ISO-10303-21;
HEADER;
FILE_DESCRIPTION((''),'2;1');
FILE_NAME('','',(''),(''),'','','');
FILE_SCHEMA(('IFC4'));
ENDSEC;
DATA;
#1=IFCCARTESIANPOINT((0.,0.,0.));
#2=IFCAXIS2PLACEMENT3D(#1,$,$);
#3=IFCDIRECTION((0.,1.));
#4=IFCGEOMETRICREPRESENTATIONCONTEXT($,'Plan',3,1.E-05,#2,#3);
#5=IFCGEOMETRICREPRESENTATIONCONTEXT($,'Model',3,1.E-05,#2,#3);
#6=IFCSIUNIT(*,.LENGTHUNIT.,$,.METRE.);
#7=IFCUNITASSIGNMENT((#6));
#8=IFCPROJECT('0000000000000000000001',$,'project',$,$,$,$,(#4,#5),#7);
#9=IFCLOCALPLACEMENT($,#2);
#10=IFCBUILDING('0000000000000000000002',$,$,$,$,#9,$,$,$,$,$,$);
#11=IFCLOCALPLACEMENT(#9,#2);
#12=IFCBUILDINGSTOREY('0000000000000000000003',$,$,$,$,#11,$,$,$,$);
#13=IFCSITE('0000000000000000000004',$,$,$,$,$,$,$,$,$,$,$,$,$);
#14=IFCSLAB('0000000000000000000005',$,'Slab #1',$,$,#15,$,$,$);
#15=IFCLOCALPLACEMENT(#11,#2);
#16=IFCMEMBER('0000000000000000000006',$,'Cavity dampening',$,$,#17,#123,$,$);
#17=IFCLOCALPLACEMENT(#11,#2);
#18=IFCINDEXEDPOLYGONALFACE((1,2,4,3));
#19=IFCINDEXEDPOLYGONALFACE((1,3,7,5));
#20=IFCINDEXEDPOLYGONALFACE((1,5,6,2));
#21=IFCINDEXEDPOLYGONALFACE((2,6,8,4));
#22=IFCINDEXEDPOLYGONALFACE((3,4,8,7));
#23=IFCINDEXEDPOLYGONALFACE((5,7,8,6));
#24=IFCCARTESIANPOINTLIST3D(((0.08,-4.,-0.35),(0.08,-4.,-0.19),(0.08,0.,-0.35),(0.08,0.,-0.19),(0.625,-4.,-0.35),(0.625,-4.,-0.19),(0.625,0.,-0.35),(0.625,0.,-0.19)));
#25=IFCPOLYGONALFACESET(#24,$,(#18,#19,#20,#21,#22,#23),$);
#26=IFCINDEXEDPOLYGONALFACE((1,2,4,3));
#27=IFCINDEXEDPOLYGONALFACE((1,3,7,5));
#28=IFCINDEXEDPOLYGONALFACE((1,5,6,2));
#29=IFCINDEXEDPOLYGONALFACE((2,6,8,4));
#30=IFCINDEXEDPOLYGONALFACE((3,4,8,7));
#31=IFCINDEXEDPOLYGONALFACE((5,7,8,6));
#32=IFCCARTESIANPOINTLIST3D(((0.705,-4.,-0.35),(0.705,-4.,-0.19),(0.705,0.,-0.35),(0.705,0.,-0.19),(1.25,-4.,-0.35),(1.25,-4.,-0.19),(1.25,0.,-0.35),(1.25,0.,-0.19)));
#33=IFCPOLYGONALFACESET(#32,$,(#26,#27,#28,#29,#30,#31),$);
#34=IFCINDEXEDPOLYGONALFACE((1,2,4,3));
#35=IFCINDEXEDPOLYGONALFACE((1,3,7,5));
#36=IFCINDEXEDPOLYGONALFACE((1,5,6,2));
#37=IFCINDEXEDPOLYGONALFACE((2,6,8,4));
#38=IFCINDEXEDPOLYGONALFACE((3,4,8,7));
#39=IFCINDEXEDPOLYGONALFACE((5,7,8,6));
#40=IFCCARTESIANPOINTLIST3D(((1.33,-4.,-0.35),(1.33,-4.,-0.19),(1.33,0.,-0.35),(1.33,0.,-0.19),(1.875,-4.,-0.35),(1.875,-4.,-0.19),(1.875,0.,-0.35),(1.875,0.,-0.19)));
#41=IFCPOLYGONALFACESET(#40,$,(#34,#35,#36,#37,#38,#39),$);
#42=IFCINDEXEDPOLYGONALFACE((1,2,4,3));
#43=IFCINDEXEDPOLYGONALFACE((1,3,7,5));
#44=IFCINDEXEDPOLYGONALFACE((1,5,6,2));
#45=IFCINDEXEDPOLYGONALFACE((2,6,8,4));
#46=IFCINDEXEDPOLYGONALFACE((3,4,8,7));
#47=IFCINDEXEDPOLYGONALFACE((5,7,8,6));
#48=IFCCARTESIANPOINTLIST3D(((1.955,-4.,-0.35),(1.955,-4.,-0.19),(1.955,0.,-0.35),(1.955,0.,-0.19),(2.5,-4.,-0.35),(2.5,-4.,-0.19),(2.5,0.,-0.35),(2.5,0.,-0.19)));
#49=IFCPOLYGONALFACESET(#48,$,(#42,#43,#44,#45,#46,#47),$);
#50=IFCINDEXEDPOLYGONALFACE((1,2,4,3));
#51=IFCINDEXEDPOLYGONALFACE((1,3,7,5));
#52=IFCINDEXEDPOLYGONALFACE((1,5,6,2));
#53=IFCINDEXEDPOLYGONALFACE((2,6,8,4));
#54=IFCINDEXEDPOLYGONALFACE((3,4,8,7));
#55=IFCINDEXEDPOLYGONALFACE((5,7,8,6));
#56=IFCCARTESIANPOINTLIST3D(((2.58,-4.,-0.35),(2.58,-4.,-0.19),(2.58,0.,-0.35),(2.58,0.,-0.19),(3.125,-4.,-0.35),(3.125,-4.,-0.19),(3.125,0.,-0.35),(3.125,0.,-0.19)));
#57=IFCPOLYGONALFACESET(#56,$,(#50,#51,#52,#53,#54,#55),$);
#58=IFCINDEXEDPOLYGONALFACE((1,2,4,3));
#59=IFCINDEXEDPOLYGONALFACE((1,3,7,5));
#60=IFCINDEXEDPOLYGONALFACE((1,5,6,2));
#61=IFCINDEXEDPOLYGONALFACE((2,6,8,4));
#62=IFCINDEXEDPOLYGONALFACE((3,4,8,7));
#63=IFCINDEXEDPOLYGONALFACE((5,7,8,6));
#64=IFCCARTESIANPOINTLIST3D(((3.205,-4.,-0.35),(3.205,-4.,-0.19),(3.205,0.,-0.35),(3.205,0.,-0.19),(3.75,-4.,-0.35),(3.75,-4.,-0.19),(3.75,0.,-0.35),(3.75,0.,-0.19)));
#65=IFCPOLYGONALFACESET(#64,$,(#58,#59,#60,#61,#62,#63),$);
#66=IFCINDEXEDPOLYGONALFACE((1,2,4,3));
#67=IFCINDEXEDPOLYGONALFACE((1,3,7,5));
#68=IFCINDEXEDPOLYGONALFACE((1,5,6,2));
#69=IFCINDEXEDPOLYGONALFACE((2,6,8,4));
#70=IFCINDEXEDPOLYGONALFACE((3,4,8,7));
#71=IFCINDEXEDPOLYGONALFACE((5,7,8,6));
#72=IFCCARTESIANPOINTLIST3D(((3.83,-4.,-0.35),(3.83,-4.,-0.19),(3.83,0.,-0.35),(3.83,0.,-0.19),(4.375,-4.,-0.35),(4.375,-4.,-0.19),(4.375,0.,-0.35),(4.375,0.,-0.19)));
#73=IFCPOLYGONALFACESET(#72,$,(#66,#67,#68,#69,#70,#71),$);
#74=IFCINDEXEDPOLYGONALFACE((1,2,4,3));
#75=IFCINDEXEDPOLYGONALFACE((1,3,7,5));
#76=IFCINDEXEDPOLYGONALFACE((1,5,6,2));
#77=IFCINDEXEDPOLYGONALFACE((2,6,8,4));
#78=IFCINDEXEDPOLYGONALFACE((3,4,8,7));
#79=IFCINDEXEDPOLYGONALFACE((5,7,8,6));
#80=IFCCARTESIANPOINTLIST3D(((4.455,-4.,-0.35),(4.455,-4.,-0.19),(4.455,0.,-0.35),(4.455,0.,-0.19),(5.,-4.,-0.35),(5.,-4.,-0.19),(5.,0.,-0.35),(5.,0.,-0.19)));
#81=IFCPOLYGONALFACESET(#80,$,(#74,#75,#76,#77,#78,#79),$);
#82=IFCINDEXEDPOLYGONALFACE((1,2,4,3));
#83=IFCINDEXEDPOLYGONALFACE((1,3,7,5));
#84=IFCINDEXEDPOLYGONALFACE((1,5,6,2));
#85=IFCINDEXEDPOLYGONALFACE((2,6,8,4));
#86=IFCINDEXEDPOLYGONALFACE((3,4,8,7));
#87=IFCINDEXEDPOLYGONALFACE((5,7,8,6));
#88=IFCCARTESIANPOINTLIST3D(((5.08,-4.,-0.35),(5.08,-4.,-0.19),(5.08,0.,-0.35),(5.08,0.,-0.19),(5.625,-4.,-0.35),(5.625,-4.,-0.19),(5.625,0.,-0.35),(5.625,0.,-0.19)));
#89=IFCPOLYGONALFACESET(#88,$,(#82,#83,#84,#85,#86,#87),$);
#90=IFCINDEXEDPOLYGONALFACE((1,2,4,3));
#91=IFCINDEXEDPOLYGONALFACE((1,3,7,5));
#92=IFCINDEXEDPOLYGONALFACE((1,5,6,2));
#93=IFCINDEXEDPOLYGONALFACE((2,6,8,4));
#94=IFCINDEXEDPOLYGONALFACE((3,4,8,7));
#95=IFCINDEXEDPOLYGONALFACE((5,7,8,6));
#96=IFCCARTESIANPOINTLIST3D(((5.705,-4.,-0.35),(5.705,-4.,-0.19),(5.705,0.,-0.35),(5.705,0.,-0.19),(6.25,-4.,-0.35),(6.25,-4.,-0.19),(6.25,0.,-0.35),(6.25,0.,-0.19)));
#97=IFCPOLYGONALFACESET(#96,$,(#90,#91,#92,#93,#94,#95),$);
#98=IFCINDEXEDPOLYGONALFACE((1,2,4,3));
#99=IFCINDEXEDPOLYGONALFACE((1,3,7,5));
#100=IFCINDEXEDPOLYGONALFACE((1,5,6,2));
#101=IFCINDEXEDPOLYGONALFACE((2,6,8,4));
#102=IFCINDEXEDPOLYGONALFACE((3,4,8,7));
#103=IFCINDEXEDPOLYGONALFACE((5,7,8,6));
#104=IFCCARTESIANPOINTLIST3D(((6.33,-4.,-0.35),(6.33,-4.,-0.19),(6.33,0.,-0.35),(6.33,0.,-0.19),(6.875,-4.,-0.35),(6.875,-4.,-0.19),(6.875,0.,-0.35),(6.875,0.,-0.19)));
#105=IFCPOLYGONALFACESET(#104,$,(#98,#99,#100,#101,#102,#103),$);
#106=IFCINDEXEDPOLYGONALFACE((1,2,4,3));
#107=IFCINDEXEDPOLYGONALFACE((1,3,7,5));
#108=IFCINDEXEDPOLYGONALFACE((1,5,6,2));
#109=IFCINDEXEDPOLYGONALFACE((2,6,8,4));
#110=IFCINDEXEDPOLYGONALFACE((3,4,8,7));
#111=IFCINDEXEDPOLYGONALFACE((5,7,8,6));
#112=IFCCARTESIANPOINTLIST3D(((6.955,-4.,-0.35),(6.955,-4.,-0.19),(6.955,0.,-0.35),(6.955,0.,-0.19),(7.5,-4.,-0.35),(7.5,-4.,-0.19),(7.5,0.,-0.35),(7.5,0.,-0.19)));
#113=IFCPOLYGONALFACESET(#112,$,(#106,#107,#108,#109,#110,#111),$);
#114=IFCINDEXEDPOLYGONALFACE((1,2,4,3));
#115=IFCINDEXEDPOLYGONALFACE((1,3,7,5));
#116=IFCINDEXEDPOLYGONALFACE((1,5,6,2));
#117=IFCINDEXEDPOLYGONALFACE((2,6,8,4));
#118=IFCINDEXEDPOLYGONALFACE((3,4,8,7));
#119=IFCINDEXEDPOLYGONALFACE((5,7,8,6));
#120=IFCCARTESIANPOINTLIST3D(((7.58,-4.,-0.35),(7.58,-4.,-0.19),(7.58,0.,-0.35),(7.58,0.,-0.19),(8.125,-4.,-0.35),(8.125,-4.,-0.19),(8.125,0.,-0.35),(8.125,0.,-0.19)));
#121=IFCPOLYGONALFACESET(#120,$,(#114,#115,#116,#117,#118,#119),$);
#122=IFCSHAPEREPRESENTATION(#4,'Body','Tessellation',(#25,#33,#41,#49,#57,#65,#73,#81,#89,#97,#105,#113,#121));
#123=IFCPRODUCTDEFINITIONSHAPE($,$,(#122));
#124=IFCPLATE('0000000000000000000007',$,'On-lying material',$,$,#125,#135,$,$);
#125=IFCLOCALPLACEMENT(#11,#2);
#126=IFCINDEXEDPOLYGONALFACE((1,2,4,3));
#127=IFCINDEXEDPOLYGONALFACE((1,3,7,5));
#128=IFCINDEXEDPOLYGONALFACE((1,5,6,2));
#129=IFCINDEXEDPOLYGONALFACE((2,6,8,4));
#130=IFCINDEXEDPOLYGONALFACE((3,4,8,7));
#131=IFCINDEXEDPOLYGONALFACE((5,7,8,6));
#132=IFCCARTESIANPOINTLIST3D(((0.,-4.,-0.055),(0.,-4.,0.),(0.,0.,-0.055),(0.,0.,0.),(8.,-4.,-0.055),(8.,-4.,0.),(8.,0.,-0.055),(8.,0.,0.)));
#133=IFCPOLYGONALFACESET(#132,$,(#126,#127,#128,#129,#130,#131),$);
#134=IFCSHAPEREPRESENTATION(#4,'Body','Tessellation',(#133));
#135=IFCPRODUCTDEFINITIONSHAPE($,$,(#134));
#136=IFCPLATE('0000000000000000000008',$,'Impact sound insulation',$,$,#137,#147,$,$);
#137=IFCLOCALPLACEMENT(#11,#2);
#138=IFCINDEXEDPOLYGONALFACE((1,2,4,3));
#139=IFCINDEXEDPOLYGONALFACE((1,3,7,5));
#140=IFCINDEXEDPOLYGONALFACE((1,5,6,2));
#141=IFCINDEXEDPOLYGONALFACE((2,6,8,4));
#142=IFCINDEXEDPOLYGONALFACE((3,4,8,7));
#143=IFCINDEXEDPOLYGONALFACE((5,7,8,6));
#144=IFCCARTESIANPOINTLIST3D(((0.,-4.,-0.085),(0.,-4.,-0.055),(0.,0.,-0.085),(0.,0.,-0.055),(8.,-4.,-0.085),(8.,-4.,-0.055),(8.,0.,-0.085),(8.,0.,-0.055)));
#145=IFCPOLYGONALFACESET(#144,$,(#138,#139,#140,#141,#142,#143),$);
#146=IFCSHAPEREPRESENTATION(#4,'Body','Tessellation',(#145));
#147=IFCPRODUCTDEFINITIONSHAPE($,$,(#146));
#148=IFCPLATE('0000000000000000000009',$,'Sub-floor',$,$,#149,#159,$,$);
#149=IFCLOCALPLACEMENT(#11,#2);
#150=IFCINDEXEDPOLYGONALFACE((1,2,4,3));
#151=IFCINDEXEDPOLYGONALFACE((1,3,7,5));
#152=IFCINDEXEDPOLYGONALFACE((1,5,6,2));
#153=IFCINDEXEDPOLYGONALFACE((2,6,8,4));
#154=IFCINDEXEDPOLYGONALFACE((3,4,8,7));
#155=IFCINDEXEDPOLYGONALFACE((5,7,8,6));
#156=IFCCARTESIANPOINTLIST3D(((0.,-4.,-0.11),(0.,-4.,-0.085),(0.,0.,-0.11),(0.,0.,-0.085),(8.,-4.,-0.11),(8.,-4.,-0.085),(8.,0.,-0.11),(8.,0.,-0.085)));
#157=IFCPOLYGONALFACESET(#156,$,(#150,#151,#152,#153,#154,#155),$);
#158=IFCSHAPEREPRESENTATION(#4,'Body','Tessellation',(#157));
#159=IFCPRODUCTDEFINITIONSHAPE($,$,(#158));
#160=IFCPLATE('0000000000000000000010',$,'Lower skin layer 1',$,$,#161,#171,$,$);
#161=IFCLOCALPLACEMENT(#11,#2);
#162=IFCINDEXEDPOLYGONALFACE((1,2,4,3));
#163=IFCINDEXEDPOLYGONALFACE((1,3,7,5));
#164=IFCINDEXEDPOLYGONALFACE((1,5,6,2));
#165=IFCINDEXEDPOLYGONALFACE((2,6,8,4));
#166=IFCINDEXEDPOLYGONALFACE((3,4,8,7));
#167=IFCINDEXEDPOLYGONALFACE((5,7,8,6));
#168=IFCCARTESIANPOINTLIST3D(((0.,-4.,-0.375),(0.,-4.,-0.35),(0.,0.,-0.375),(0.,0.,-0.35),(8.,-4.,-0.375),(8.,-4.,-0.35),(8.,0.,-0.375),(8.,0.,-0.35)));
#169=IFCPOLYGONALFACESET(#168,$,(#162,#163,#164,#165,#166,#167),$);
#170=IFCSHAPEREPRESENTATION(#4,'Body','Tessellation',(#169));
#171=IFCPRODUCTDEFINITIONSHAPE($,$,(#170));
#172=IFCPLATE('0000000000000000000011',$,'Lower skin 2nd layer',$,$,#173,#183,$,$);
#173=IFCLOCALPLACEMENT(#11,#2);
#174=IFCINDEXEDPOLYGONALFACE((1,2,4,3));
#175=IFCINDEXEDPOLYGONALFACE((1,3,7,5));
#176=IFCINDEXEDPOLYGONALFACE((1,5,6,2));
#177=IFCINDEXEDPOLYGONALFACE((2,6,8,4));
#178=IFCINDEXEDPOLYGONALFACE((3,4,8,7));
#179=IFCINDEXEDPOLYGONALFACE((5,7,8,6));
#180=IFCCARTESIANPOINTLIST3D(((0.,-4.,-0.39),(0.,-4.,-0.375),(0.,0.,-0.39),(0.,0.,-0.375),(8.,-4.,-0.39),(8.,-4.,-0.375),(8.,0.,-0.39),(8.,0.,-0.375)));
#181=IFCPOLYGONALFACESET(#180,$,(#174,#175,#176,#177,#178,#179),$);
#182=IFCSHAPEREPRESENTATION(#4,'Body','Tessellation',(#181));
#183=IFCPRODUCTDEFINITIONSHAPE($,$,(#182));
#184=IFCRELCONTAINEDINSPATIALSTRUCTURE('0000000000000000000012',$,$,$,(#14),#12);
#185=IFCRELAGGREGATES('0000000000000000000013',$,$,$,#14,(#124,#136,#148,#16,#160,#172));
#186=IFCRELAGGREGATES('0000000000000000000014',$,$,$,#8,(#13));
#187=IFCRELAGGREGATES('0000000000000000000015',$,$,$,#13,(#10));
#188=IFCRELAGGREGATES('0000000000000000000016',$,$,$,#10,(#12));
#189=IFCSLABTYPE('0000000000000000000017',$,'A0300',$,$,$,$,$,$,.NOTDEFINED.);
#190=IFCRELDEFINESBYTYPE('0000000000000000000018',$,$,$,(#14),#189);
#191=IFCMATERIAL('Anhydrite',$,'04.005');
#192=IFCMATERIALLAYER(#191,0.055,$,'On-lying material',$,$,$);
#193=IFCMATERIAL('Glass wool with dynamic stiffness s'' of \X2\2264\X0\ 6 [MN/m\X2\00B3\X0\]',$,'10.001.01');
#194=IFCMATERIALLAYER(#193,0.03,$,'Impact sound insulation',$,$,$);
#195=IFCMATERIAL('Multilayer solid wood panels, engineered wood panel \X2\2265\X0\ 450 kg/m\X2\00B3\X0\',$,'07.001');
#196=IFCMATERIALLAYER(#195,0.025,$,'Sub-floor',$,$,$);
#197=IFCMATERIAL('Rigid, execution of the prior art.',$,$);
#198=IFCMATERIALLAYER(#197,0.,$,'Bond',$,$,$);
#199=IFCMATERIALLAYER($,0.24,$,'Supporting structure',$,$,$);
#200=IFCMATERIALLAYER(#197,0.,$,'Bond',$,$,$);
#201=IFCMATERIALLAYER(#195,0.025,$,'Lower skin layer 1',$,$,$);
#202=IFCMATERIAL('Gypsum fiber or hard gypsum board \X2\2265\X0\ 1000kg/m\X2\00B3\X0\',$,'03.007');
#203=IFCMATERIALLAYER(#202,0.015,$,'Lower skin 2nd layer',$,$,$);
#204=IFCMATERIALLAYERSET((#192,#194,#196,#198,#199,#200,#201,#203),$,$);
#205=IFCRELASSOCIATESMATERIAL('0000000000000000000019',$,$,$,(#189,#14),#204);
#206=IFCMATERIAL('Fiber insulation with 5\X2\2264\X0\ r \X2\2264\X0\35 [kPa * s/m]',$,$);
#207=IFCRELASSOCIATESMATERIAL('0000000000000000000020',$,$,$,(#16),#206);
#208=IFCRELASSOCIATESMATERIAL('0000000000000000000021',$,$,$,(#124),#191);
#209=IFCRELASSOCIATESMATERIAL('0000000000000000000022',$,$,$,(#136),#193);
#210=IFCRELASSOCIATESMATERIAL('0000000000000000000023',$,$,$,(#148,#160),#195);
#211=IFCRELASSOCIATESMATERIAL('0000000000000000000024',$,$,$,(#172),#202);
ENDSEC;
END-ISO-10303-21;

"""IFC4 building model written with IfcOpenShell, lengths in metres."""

from ifc_helpers import new_model, si_unit, direction, frame, frame_2d, origin, origin_with_axes, place, context, project, spatial, rectangle, extrude, material, layer, layer_set, type_object, element, aggregate, save


model = new_model("IFC4")

# Units and contexts
plan_context = context("Plan", 3, precision=1e-05, world=origin(), true_north=direction((0.0, 1.0)))
model_context = context("Model", 3, precision=1e-05, world=origin(), true_north=direction((0.0, 1.0)))
ifc_project = project(units=[si_unit("LENGTHUNIT", "METRE")], contexts=[plan_context, model_context])

# Site, building, storey
site = spatial("IfcSite", under=ifc_project)
building_placement = place(None, origin())
building = spatial("IfcBuilding", under=site, at=building_placement)
storey_placement = place(building_placement, origin())
storey = spatial("IfcBuildingStorey", under=building, at=storey_placement)

# Slab, member, plates
ifc_material_1 = material(Name="Anhydrite", Category="04.005")
ifc_layer_1 = layer(ifc_material_1, 0.055, Name="On-lying material")
ifc_material_2 = material(Name="Glass wool with dynamic stiffness s' of ≤ 6 [MN/m³]", Category="10.001.01")
ifc_layer_2 = layer(ifc_material_2, 0.03, Name="Impact sound insulation")
ifc_material_3 = material(Name="Multilayer solid wood panels, engineered wood panel ≥ 450 kg/m³", Category="07.001")
ifc_layer_3 = layer(ifc_material_3, 0.025, Name="Sub-floor")
ifc_material_4 = material(Name="Rigid, execution of the prior art.")
ifc_layer_4 = layer(ifc_material_4, 0.0, Name="Bond")
ifc_layer_5 = layer(None, 0.24, Name="Supporting structure")
ifc_layer_6 = layer(ifc_material_4, 0.0, Name="Bond")
ifc_layer_7 = layer(ifc_material_3, 0.025, Name="Lower skin layer 1")
ifc_material_5 = material(Name="Gypsum fiber or hard gypsum board ≥ 1000kg/m³", Category="03.007")
ifc_layer_8 = layer(ifc_material_5, 0.015, Name="Lower skin 2nd layer")
ifc_layer_set = layer_set([ifc_layer_1, ifc_layer_2, ifc_layer_3, ifc_layer_4, ifc_layer_5, ifc_layer_6, ifc_layer_7, ifc_layer_8])
slab_type = type_object("IfcSlabType", Name="A0300", PredefinedType="NOTDEFINED", material=ifc_layer_set)
slab_placement = place(None, frame((0.0, 0.0, 0.0), z_axis=(0.0, 0.0, -1.0), x_axis=(1.0, 0.0, 0.0)))
slab = element("IfcSlab", 1, at=slab_placement, inside=storey, type_object=slab_type, material=ifc_layer_set, Name="Slab #1")
ifc_material_6 = material(Name="Fiber insulation with 5≤ r ≤35 [kPa * s/m]")
member_1_placement = place(slab_placement, origin())
member_1 = element("IfcMember", 2, at=member_1_placement, material=ifc_material_6, Name="Cavity dampening", context=plan_context, shape_type="SweptSolid", body=[
    extrude(rectangle(XDim=0.545, YDim=0.16, at=frame_2d((0.2725, 0.08), x_axis=(1.0, 0.0))), frame((0.08, 4.0, 0.19), z_axis=(0.0, -1.0, 0.0), x_axis=(1.0, 0.0, 0.0)), (0.0, 0.0, 1.0), 4.0),
    extrude(rectangle(XDim=0.545, YDim=0.16, at=frame_2d((0.2725, 0.08), x_axis=(1.0, 0.0))), frame((0.705, 4.0, 0.19), z_axis=(0.0, -1.0, 0.0), x_axis=(1.0, 0.0, 0.0)), (0.0, 0.0, 1.0), 4.0),
    extrude(rectangle(XDim=0.545, YDim=0.16, at=frame_2d((0.2725, 0.08), x_axis=(1.0, 0.0))), frame((1.33, 4.0, 0.19), z_axis=(0.0, -1.0, 0.0), x_axis=(1.0, 0.0, 0.0)), (0.0, 0.0, 1.0), 4.0),
    extrude(rectangle(XDim=0.545, YDim=0.16, at=frame_2d((0.2725, 0.08), x_axis=(1.0, 0.0))), frame((1.955, 4.0, 0.19), z_axis=(0.0, -1.0, 0.0), x_axis=(1.0, 0.0, 0.0)), (0.0, 0.0, 1.0), 4.0),
    extrude(rectangle(XDim=0.545, YDim=0.16, at=frame_2d((0.2725, 0.08), x_axis=(1.0, 0.0))), frame((2.58, 4.0, 0.19), z_axis=(0.0, -1.0, 0.0), x_axis=(1.0, 0.0, 0.0)), (0.0, 0.0, 1.0), 4.0),
    extrude(rectangle(XDim=0.545, YDim=0.16, at=frame_2d((0.2725, 0.08), x_axis=(1.0, 0.0))), frame((3.205, 4.0, 0.19), z_axis=(0.0, -1.0, 0.0), x_axis=(1.0, 0.0, 0.0)), (0.0, 0.0, 1.0), 4.0),
    extrude(rectangle(XDim=0.545, YDim=0.16, at=frame_2d((0.2725, 0.08), x_axis=(1.0, 0.0))), frame((3.83, 4.0, 0.19), z_axis=(0.0, -1.0, 0.0), x_axis=(1.0, 0.0, 0.0)), (0.0, 0.0, 1.0), 4.0),
    extrude(rectangle(XDim=0.545, YDim=0.16, at=frame_2d((0.2725, 0.08), x_axis=(1.0, 0.0))), frame((4.455, 4.0, 0.19), z_axis=(0.0, -1.0, 0.0), x_axis=(1.0, 0.0, 0.0)), (0.0, 0.0, 1.0), 4.0),
    extrude(rectangle(XDim=0.545, YDim=0.16, at=frame_2d((0.2725, 0.08), x_axis=(1.0, 0.0))), frame((5.08, 4.0, 0.19), z_axis=(0.0, -1.0, 0.0), x_axis=(1.0, 0.0, 0.0)), (0.0, 0.0, 1.0), 4.0),
    extrude(rectangle(XDim=0.545, YDim=0.16, at=frame_2d((0.2725, 0.08), x_axis=(1.0, 0.0))), frame((5.705, 4.0, 0.19), z_axis=(0.0, -1.0, 0.0), x_axis=(1.0, 0.0, 0.0)), (0.0, 0.0, 1.0), 4.0),
    extrude(rectangle(XDim=0.545, YDim=0.16, at=frame_2d((0.2725, 0.08), x_axis=(1.0, 0.0))), frame((6.33, 4.0, 0.19), z_axis=(0.0, -1.0, 0.0), x_axis=(1.0, 0.0, 0.0)), (0.0, 0.0, 1.0), 4.0),
    extrude(rectangle(XDim=0.545, YDim=0.16, at=frame_2d((0.2725, 0.08), x_axis=(1.0, 0.0))), frame((6.955, 4.0, 0.19), z_axis=(0.0, -1.0, 0.0), x_axis=(1.0, 0.0, 0.0)), (0.0, 0.0, 1.0), 4.0),
    extrude(rectangle(XDim=0.545, YDim=0.16, at=frame_2d((0.2725, 0.08), x_axis=(1.0, 0.0))), frame((7.58, 4.0, 0.19), z_axis=(0.0, -1.0, 0.0), x_axis=(1.0, 0.0, 0.0)), (0.0, 0.0, 1.0), 4.0),
])
plate_1_placement = place(slab_placement, origin())
plate_1 = element("IfcPlate", 3, at=plate_1_placement, material=ifc_material_1, Name="On-lying material", context=plan_context, shape_type="SweptSolid", body=[
    extrude(rectangle(XDim=8.0, YDim=4.0, at=frame_2d((4.0, 2.0), x_axis=(1.0, 0.0))), origin_with_axes(), (0.0, 0.0, 1.0), 0.055),
])
plate_2_placement = place(slab_placement, origin())
plate_2 = element("IfcPlate", 4, at=plate_2_placement, material=ifc_material_2, Name="Impact sound insulation", context=plan_context, shape_type="SweptSolid", body=[
    extrude(rectangle(XDim=8.0, YDim=4.0, at=frame_2d((4.0, 2.0), x_axis=(1.0, 0.0))), frame((0.0, 0.0, 0.055), z_axis=(0.0, 0.0, 1.0), x_axis=(1.0, 0.0, 0.0)), (0.0, 0.0, 1.0), 0.03),
])
plate_3_placement = place(slab_placement, origin())
plate_3 = element("IfcPlate", 5, at=plate_3_placement, material=ifc_material_3, Name="Sub-floor", context=plan_context, shape_type="SweptSolid", body=[
    extrude(rectangle(XDim=8.0, YDim=4.0, at=frame_2d((4.0, 2.0), x_axis=(1.0, 0.0))), frame((0.0, 0.0, 0.085), z_axis=(0.0, 0.0, 1.0), x_axis=(1.0, 0.0, 0.0)), (0.0, 0.0, 1.0), 0.025),
])
plate_4_placement = place(slab_placement, origin())
plate_4 = element("IfcPlate", 6, at=plate_4_placement, material=ifc_material_3, Name="Lower skin layer 1", context=plan_context, shape_type="SweptSolid", body=[
    extrude(rectangle(XDim=8.0, YDim=4.0, at=frame_2d((4.0, 2.0), x_axis=(1.0, 0.0))), frame((0.0, 0.0, 0.35), z_axis=(0.0, 0.0, 1.0), x_axis=(1.0, 0.0, 0.0)), (0.0, 0.0, 1.0), 0.025),
])
plate_5_placement = place(slab_placement, origin())
plate_5 = element("IfcPlate", 7, at=plate_5_placement, material=ifc_material_5, Name="Lower skin 2nd layer", context=plan_context, shape_type="SweptSolid", body=[
    extrude(rectangle(XDim=8.0, YDim=4.0, at=frame_2d((4.0, 2.0), x_axis=(1.0, 0.0))), frame((0.0, 0.0, 0.375), z_axis=(0.0, 0.0, 1.0), x_axis=(1.0, 0.0, 0.0)), (0.0, 0.0, 1.0), 0.015),
])
aggregate(slab, [plate_1, plate_2, plate_3, member_1, plate_4, plate_5])

save(model, "model.ifc")
